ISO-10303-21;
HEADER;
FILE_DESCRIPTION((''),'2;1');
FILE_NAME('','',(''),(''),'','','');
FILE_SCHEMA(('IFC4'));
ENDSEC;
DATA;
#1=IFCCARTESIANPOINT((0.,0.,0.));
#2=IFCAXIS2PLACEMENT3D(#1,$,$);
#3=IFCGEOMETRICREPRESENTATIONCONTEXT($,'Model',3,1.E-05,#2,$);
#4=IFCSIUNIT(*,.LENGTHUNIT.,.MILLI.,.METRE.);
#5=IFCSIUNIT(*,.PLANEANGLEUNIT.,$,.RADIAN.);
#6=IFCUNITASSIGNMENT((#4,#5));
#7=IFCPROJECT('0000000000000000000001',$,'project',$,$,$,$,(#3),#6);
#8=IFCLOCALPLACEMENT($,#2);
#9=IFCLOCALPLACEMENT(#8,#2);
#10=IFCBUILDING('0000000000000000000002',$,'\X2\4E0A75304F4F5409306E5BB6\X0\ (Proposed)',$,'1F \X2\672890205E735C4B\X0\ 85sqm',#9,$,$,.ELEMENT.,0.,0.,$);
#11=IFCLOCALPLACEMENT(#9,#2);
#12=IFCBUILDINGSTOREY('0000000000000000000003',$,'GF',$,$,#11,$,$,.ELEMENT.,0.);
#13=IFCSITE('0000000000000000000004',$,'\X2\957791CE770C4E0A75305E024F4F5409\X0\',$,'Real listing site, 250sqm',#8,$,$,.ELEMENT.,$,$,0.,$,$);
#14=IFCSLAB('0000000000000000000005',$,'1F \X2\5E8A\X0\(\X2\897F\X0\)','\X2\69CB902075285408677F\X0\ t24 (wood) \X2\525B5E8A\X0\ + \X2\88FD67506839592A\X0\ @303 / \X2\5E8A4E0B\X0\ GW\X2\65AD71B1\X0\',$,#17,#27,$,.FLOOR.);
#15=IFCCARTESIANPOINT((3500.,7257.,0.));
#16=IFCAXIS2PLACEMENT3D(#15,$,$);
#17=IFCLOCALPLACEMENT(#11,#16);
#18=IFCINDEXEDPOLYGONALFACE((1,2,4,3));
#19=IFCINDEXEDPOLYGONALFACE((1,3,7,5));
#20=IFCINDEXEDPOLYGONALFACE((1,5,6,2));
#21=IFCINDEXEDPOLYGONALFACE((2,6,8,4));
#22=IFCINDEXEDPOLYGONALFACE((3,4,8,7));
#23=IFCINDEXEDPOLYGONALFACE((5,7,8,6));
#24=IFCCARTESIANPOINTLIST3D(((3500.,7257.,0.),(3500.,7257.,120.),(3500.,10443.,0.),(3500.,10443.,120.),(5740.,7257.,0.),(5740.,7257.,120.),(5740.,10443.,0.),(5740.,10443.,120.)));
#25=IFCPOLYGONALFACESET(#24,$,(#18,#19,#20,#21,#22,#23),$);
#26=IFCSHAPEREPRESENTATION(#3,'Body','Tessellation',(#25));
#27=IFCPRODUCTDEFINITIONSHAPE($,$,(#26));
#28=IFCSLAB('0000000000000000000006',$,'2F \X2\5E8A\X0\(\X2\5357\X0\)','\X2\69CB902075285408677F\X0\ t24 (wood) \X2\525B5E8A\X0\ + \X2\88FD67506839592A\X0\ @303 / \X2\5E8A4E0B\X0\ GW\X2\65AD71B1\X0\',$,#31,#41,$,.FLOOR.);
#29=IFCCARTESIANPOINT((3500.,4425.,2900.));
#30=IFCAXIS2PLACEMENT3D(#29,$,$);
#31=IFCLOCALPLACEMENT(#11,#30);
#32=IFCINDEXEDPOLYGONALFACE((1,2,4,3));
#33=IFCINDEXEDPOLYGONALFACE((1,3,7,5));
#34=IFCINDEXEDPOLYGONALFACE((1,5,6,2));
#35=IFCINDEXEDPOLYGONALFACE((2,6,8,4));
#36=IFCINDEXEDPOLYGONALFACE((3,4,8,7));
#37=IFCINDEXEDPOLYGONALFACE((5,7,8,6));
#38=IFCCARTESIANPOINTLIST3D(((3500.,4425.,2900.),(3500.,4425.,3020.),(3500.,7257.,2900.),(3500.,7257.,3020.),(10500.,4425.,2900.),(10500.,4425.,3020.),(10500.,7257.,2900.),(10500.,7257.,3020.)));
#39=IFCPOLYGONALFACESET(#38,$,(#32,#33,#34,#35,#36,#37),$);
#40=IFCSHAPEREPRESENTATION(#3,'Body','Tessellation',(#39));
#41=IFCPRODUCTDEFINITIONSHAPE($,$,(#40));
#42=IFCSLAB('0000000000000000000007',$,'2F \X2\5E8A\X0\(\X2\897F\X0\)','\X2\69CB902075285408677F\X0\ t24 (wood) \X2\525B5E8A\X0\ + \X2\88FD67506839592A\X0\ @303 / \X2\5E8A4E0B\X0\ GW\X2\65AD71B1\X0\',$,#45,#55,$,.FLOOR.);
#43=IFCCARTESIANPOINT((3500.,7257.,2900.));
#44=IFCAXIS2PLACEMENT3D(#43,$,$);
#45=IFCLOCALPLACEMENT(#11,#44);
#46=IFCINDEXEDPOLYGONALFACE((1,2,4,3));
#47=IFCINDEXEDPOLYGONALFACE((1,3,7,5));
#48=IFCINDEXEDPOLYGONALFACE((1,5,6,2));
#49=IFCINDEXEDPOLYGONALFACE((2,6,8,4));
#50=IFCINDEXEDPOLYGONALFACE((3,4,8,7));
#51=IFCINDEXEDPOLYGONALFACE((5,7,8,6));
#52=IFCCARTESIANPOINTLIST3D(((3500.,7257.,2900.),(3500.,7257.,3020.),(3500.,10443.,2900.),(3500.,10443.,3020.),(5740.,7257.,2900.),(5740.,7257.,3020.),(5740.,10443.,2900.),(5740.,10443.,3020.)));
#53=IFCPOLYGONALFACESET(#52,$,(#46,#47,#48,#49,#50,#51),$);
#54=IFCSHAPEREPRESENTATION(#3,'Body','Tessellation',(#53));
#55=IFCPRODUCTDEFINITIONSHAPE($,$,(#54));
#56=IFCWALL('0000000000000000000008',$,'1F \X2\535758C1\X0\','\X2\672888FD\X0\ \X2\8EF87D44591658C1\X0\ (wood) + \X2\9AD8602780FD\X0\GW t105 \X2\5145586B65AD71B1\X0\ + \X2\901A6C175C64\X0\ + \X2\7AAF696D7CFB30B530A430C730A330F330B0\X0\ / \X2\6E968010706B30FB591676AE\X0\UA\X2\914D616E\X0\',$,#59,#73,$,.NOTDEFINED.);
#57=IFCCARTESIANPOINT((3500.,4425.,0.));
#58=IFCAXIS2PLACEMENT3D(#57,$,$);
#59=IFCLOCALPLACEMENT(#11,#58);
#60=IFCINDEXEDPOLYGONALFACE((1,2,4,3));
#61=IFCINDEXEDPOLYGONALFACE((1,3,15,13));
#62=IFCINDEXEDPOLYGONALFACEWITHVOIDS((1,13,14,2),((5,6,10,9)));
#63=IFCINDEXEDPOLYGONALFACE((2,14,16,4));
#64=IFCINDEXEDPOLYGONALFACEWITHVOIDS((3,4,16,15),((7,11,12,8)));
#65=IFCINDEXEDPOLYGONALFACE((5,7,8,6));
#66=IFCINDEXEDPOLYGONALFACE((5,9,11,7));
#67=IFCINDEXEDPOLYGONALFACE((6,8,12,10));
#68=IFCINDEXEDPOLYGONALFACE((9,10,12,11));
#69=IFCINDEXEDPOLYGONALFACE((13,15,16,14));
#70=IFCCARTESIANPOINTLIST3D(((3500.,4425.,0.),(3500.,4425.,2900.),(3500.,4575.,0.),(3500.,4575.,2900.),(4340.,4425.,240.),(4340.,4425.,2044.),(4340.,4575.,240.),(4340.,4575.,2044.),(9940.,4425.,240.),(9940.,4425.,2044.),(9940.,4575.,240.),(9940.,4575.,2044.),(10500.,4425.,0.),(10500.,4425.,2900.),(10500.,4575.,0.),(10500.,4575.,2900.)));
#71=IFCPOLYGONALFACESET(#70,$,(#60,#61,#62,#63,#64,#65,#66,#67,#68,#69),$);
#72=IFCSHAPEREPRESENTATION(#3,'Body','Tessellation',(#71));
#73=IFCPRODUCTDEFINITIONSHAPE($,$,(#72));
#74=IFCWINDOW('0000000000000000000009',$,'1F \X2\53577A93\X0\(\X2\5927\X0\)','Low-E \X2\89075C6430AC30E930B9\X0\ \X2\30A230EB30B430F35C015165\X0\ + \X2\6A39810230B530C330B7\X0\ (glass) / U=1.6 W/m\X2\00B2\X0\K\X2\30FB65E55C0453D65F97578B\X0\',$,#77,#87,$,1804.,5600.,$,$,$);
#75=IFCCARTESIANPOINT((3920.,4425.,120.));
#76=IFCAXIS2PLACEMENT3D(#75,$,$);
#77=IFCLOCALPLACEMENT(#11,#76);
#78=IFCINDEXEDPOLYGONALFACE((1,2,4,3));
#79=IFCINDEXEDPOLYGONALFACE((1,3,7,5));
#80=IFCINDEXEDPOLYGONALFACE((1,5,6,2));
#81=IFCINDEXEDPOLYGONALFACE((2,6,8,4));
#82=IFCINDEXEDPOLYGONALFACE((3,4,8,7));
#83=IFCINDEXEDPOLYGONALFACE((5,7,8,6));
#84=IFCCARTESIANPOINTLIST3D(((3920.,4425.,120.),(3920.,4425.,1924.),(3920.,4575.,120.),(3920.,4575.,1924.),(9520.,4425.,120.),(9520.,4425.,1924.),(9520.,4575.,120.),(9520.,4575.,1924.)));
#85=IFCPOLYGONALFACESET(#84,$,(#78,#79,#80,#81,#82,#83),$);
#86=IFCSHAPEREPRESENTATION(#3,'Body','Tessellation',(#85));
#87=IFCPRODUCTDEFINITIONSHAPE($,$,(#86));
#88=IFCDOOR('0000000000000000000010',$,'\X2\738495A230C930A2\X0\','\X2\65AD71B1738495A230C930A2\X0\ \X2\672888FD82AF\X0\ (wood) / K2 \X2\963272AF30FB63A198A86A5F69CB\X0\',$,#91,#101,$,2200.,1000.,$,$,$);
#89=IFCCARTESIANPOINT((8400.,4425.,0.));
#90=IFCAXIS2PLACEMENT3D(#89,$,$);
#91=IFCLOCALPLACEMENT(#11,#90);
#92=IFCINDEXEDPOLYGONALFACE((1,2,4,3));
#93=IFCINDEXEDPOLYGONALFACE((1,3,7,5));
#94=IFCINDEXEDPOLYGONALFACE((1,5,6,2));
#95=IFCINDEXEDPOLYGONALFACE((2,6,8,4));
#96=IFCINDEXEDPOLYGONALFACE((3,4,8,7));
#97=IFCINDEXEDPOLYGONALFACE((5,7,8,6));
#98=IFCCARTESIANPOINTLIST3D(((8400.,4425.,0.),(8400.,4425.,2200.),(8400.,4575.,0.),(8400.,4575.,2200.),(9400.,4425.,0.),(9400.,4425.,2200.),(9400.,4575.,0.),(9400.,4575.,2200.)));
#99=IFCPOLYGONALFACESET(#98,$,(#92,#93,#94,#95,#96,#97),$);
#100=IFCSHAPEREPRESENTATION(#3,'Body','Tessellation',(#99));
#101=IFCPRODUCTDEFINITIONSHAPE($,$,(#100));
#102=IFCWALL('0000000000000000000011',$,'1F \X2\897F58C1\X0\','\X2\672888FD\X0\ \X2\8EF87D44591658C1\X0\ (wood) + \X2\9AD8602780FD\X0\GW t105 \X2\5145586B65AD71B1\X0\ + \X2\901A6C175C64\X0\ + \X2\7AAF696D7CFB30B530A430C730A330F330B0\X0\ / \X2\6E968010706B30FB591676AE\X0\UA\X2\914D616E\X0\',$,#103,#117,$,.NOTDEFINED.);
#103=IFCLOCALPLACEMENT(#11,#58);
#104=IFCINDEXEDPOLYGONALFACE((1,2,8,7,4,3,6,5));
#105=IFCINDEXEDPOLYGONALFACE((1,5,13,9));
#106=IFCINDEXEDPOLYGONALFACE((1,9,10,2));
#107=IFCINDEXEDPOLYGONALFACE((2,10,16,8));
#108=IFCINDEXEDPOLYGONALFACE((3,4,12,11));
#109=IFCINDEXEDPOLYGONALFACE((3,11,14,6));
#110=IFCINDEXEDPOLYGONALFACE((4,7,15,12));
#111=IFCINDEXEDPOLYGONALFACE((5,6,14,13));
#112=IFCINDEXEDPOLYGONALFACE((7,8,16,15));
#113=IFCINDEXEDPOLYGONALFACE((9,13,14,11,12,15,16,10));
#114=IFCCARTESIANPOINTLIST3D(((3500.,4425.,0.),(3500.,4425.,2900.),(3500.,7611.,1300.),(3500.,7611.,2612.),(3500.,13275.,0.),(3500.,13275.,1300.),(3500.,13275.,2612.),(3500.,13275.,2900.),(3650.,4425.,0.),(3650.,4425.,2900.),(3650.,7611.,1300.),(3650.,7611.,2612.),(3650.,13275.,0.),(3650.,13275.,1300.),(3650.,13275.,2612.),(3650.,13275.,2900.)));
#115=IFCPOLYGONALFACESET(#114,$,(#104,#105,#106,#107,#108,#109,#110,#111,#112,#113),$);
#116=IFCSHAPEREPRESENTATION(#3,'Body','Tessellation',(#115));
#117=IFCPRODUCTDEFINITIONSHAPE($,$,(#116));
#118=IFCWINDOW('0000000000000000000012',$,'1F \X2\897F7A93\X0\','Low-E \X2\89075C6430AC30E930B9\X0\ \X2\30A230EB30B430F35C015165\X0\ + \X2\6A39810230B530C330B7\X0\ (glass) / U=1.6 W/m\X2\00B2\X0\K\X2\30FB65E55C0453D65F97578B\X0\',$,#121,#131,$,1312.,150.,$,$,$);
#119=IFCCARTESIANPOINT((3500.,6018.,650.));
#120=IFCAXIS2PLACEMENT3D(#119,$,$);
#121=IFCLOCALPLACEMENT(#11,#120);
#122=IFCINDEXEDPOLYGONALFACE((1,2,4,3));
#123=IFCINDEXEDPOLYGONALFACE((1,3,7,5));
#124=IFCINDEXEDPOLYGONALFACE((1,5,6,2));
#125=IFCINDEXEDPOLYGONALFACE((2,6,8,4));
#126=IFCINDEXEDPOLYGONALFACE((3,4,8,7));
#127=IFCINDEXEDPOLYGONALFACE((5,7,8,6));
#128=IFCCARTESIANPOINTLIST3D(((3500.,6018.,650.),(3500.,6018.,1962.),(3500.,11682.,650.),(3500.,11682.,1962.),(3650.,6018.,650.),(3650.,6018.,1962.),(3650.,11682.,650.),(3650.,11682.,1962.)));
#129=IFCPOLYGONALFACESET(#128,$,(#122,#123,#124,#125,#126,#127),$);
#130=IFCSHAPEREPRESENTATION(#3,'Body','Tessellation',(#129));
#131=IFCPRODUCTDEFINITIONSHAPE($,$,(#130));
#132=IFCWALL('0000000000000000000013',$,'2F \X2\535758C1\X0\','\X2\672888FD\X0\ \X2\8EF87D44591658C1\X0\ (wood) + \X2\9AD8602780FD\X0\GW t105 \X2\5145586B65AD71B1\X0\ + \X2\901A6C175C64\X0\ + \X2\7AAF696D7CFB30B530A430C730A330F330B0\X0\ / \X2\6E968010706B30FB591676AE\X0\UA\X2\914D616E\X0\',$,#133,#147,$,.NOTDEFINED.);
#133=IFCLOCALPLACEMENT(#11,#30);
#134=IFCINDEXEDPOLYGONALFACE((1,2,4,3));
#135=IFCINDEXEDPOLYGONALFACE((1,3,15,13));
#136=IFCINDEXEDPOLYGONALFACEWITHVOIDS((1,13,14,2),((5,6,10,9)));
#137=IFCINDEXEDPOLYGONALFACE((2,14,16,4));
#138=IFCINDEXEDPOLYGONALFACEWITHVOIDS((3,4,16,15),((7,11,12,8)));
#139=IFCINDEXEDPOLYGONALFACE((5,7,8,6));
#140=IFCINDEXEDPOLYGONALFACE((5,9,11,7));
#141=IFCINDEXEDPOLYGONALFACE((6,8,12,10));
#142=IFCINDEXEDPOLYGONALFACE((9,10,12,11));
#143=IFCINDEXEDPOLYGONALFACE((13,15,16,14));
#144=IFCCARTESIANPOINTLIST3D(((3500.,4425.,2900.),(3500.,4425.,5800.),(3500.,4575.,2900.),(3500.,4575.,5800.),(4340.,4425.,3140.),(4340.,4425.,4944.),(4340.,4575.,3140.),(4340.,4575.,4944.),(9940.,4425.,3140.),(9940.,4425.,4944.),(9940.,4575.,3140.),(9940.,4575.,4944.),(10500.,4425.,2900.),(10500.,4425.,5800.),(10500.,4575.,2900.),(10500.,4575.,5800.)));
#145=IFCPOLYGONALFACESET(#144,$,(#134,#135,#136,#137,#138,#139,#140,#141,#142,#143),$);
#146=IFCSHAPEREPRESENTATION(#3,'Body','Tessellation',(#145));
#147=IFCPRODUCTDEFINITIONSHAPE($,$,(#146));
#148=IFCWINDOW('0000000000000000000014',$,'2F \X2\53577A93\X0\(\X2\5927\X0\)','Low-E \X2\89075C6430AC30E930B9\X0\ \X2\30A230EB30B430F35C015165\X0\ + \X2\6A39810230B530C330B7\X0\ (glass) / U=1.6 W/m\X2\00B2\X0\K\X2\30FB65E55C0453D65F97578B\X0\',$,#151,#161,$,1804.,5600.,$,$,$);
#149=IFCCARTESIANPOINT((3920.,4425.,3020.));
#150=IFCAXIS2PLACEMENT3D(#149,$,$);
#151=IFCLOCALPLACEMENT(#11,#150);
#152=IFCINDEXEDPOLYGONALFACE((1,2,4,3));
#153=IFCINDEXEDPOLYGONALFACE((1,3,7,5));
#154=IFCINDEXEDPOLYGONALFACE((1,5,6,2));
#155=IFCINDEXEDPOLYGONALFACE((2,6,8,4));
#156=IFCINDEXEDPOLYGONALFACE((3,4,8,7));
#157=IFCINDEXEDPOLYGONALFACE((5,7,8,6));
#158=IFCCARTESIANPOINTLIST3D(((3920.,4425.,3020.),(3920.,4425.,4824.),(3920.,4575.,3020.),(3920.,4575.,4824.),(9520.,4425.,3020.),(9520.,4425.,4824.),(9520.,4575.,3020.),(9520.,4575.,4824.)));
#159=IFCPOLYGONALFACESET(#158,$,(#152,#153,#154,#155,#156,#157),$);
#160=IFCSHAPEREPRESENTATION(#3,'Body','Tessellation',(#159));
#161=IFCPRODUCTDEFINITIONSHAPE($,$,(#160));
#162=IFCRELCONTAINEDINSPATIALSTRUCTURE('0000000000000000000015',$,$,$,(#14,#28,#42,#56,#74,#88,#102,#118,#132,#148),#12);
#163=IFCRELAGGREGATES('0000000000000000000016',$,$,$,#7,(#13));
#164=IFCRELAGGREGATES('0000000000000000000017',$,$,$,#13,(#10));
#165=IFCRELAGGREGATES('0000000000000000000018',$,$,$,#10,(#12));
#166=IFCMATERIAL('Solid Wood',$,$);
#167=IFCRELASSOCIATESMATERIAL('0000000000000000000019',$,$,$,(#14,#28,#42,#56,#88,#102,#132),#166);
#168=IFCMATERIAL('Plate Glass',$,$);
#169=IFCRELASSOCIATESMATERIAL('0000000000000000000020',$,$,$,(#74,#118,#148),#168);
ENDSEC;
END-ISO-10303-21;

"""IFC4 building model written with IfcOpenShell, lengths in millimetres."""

from ifc_helpers import new_model, si_unit, frame, frame_2d, origin, place, context, project, spatial, rectangle, extrude, material, element, fill, save


model = new_model("IFC4")

# Units and contexts
model_context = context("Model", 3, precision=1e-05, world=origin())
ifc_project = project(units=[si_unit("LENGTHUNIT", "METRE", prefix="MILLI"), si_unit("PLANEANGLEUNIT", "RADIAN")], contexts=[model_context])

# Site, building, storey
site_placement = place(None, origin())
site = spatial("IfcSite", under=ifc_project, at=site_placement, Name="長野県上田市住吉", ObjectType="Real listing site, 250sqm", CompositionType="ELEMENT", RefElevation=0.0)
building_placement = place(site_placement, origin())
building = spatial("IfcBuilding", under=site, at=building_placement, Name="上田住吉の家 (Proposed)", ObjectType="1F 木造平屋 85sqm", CompositionType="ELEMENT", ElevationOfRefHeight=0.0, ElevationOfTerrain=0.0)
storey_placement = place(building_placement, origin())
storey = spatial("IfcBuildingStorey", under=building, at=storey_placement, Name="GF", CompositionType="ELEMENT", Elevation=0.0)

# Slabs
ifc_material_1 = material(Name="Solid Wood")
slab_1_placement = place(storey_placement, frame((3500.0, 7257.0, 0.0)))
element("IfcSlab", 1, at=slab_1_placement, inside=storey, material=ifc_material_1, Name="1F 床(西)", Description="構造用合板 t24 (wood) 剛床 + 製材根太 @303 / 床下 GW断熱", PredefinedType="FLOOR", context=model_context, shape_type="SweptSolid", body=[
    extrude(rectangle(XDim=2240.0, YDim=3186.0, at=frame_2d((1120.0, 1593.0))), frame((3500.0, 7257.0, 0.0)), (0.0, 0.0, 1.0), 120.0),
])
slab_2_placement = place(storey_placement, frame((3500.0, 4425.0, 2900.0)))
element("IfcSlab", 2, at=slab_2_placement, inside=storey, material=ifc_material_1, Name="2F 床(南)", Description="構造用合板 t24 (wood) 剛床 + 製材根太 @303 / 床下 GW断熱", PredefinedType="FLOOR", context=model_context, shape_type="SweptSolid", body=[
    extrude(rectangle(XDim=7000.0, YDim=2832.0, at=frame_2d((3500.0, 1416.0))), frame((3500.0, 4425.0, 2900.0)), (0.0, 0.0, 1.0), 120.0),
])
slab_3_placement = place(storey_placement, frame((3500.0, 7257.0, 2900.0)))
element("IfcSlab", 3, at=slab_3_placement, inside=storey, material=ifc_material_1, Name="2F 床(西)", Description="構造用合板 t24 (wood) 剛床 + 製材根太 @303 / 床下 GW断熱", PredefinedType="FLOOR", context=model_context, shape_type="SweptSolid", body=[
    extrude(rectangle(XDim=2240.0, YDim=3186.0, at=frame_2d((1120.0, 1593.0))), frame((3500.0, 7257.0, 2900.0)), (0.0, 0.0, 1.0), 120.0),
])

# Wall, openings, window, door
wall_1_placement = place(storey_placement, frame((3500.0, 4425.0, 0.0)))
wall_1 = element("IfcWall", 4, at=wall_1_placement, inside=storey, material=ifc_material_1, Name="1F 南壁", Description="木製 軸組外壁 (wood) + 高性能GW t105 充填断熱 + 通気層 + 窯業系サイディング / 準耐火・外皮UA配慮", PredefinedType="NOTDEFINED", context=model_context, shape_type="SweptSolid", body=[
    extrude(rectangle(XDim=7000.0, YDim=150.0, at=frame_2d((3500.0, 75.0))), frame((3500.0, 4425.0, 0.0)), (0.0, 0.0, 1.0), 2900.0),
])
opening_1_placement = place(storey_placement, frame((3920.0, 4425.0, 120.0)))
opening_1 = element("IfcOpeningElement", 5, at=opening_1_placement, cuts=wall_1, PredefinedType="NOTDEFINED", context=model_context, shape_type="SweptSolid", body=[
    extrude(rectangle(XDim=5600.0, YDim=150.0, at=frame_2d((2800.0, 75.0))), frame((3920.0, 4425.0, 120.0)), (0.0, 0.0, 1.0), 1804.0),
])
opening_2_placement = place(storey_placement, frame((8400.0, 4425.0, 0.0)))
opening_2 = element("IfcOpeningElement", 6, at=opening_2_placement, cuts=wall_1, PredefinedType="NOTDEFINED", context=model_context, shape_type="SweptSolid", body=[
    extrude(rectangle(XDim=1000.0, YDim=150.0, at=frame_2d((500.0, 75.0))), frame((8400.0, 4425.0, 0.0)), (0.0, 0.0, 1.0), 2200.0),
])
ifc_material_2 = material(Name="Plate Glass")
window_1_placement = place(storey_placement, frame((3920.0, 4425.0, 120.0)))
window_1 = element("IfcWindow", 7, at=window_1_placement, inside=storey, material=ifc_material_2, Name="1F 南窓(大)", Description="Low-E 複層ガラス アルゴン封入 + 樹脂サッシ (glass) / U=1.6 W/m²K・日射取得型", OverallHeight=1804.0, OverallWidth=5600.0, context=model_context, shape_type="SweptSolid", body=[
    extrude(rectangle(XDim=5600.0, YDim=150.0, at=frame_2d((2800.0, 75.0))), frame((3920.0, 4425.0, 120.0)), (0.0, 0.0, 1.0), 1804.0),
])
fill(opening_1, window_1)
door_placement = place(storey_placement, frame((8400.0, 4425.0, 0.0)))
door = element("IfcDoor", 8, at=door_placement, inside=storey, material=ifc_material_1, Name="玄関ドア", Description="断熱玄関ドア 木製芯 (wood) / K2 防犯・採風機構", OverallHeight=2200.0, OverallWidth=1000.0, context=model_context, shape_type="SweptSolid", body=[
    extrude(rectangle(XDim=1000.0, YDim=150.0, at=frame_2d((500.0, 75.0))), frame((8400.0, 4425.0, 0.0)), (0.0, 0.0, 1.0), 2200.0),
])
fill(opening_2, door)

# Walls, openings, windows
wall_2_placement = place(storey_placement, frame((3500.0, 4425.0, 0.0)))
wall_2 = element("IfcWall", 9, at=wall_2_placement, inside=storey, material=ifc_material_1, Name="1F 西壁", Description="木製 軸組外壁 (wood) + 高性能GW t105 充填断熱 + 通気層 + 窯業系サイディング / 準耐火・外皮UA配慮", PredefinedType="NOTDEFINED", context=model_context, shape_type="SweptSolid", body=[
    extrude(rectangle(XDim=150.0, YDim=8850.0, at=frame_2d((75.0, 4425.0))), frame((3500.0, 4425.0, 0.0)), (0.0, 0.0, 1.0), 2900.0),
])
opening_3_placement = place(storey_placement, frame((3500.0, 6018.0, 650.0)))
opening_3 = element("IfcOpeningElement", 10, at=opening_3_placement, cuts=wall_2, PredefinedType="NOTDEFINED", context=model_context, shape_type="SweptSolid", body=[
    extrude(rectangle(XDim=150.0, YDim=5664.0, at=frame_2d((75.0, 2832.0))), frame((3500.0, 6018.0, 650.0)), (0.0, 0.0, 1.0), 1312.0),
])
window_2_placement = place(storey_placement, frame((3500.0, 6018.0, 650.0)))
window_2 = element("IfcWindow", 11, at=window_2_placement, inside=storey, material=ifc_material_2, Name="1F 西窓", Description="Low-E 複層ガラス アルゴン封入 + 樹脂サッシ (glass) / U=1.6 W/m²K・日射取得型", OverallHeight=1312.0, OverallWidth=150.0, context=model_context, shape_type="SweptSolid", body=[
    extrude(rectangle(XDim=150.0, YDim=5664.0, at=frame_2d((75.0, 2832.0))), frame((3500.0, 6018.0, 650.0)), (0.0, 0.0, 1.0), 1312.0),
])
fill(opening_3, window_2)
wall_3_placement = place(storey_placement, frame((3500.0, 4425.0, 2900.0)))
wall_3 = element("IfcWall", 12, at=wall_3_placement, inside=storey, material=ifc_material_1, Name="2F 南壁", Description="木製 軸組外壁 (wood) + 高性能GW t105 充填断熱 + 通気層 + 窯業系サイディング / 準耐火・外皮UA配慮", PredefinedType="NOTDEFINED", context=model_context, shape_type="SweptSolid", body=[
    extrude(rectangle(XDim=7000.0, YDim=150.0, at=frame_2d((3500.0, 75.0))), frame((3500.0, 4425.0, 2900.0)), (0.0, 0.0, 1.0), 2900.0),
])
opening_4_placement = place(storey_placement, frame((3920.0, 4425.0, 3020.0)))
opening_4 = element("IfcOpeningElement", 13, at=opening_4_placement, cuts=wall_3, PredefinedType="NOTDEFINED", context=model_context, shape_type="SweptSolid", body=[
    extrude(rectangle(XDim=5600.0, YDim=150.0, at=frame_2d((2800.0, 75.0))), frame((3920.0, 4425.0, 3020.0)), (0.0, 0.0, 1.0), 1804.0),
])
window_3_placement = place(storey_placement, frame((3920.0, 4425.0, 3020.0)))
window_3 = element("IfcWindow", 14, at=window_3_placement, inside=storey, material=ifc_material_2, Name="2F 南窓(大)", Description="Low-E 複層ガラス アルゴン封入 + 樹脂サッシ (glass) / U=1.6 W/m²K・日射取得型", OverallHeight=1804.0, OverallWidth=5600.0, context=model_context, shape_type="SweptSolid", body=[
    extrude(rectangle(XDim=5600.0, YDim=150.0, at=frame_2d((2800.0, 75.0))), frame((3920.0, 4425.0, 3020.0)), (0.0, 0.0, 1.0), 1804.0),
])
fill(opening_4, window_3)

save(model, "model.ifc")
